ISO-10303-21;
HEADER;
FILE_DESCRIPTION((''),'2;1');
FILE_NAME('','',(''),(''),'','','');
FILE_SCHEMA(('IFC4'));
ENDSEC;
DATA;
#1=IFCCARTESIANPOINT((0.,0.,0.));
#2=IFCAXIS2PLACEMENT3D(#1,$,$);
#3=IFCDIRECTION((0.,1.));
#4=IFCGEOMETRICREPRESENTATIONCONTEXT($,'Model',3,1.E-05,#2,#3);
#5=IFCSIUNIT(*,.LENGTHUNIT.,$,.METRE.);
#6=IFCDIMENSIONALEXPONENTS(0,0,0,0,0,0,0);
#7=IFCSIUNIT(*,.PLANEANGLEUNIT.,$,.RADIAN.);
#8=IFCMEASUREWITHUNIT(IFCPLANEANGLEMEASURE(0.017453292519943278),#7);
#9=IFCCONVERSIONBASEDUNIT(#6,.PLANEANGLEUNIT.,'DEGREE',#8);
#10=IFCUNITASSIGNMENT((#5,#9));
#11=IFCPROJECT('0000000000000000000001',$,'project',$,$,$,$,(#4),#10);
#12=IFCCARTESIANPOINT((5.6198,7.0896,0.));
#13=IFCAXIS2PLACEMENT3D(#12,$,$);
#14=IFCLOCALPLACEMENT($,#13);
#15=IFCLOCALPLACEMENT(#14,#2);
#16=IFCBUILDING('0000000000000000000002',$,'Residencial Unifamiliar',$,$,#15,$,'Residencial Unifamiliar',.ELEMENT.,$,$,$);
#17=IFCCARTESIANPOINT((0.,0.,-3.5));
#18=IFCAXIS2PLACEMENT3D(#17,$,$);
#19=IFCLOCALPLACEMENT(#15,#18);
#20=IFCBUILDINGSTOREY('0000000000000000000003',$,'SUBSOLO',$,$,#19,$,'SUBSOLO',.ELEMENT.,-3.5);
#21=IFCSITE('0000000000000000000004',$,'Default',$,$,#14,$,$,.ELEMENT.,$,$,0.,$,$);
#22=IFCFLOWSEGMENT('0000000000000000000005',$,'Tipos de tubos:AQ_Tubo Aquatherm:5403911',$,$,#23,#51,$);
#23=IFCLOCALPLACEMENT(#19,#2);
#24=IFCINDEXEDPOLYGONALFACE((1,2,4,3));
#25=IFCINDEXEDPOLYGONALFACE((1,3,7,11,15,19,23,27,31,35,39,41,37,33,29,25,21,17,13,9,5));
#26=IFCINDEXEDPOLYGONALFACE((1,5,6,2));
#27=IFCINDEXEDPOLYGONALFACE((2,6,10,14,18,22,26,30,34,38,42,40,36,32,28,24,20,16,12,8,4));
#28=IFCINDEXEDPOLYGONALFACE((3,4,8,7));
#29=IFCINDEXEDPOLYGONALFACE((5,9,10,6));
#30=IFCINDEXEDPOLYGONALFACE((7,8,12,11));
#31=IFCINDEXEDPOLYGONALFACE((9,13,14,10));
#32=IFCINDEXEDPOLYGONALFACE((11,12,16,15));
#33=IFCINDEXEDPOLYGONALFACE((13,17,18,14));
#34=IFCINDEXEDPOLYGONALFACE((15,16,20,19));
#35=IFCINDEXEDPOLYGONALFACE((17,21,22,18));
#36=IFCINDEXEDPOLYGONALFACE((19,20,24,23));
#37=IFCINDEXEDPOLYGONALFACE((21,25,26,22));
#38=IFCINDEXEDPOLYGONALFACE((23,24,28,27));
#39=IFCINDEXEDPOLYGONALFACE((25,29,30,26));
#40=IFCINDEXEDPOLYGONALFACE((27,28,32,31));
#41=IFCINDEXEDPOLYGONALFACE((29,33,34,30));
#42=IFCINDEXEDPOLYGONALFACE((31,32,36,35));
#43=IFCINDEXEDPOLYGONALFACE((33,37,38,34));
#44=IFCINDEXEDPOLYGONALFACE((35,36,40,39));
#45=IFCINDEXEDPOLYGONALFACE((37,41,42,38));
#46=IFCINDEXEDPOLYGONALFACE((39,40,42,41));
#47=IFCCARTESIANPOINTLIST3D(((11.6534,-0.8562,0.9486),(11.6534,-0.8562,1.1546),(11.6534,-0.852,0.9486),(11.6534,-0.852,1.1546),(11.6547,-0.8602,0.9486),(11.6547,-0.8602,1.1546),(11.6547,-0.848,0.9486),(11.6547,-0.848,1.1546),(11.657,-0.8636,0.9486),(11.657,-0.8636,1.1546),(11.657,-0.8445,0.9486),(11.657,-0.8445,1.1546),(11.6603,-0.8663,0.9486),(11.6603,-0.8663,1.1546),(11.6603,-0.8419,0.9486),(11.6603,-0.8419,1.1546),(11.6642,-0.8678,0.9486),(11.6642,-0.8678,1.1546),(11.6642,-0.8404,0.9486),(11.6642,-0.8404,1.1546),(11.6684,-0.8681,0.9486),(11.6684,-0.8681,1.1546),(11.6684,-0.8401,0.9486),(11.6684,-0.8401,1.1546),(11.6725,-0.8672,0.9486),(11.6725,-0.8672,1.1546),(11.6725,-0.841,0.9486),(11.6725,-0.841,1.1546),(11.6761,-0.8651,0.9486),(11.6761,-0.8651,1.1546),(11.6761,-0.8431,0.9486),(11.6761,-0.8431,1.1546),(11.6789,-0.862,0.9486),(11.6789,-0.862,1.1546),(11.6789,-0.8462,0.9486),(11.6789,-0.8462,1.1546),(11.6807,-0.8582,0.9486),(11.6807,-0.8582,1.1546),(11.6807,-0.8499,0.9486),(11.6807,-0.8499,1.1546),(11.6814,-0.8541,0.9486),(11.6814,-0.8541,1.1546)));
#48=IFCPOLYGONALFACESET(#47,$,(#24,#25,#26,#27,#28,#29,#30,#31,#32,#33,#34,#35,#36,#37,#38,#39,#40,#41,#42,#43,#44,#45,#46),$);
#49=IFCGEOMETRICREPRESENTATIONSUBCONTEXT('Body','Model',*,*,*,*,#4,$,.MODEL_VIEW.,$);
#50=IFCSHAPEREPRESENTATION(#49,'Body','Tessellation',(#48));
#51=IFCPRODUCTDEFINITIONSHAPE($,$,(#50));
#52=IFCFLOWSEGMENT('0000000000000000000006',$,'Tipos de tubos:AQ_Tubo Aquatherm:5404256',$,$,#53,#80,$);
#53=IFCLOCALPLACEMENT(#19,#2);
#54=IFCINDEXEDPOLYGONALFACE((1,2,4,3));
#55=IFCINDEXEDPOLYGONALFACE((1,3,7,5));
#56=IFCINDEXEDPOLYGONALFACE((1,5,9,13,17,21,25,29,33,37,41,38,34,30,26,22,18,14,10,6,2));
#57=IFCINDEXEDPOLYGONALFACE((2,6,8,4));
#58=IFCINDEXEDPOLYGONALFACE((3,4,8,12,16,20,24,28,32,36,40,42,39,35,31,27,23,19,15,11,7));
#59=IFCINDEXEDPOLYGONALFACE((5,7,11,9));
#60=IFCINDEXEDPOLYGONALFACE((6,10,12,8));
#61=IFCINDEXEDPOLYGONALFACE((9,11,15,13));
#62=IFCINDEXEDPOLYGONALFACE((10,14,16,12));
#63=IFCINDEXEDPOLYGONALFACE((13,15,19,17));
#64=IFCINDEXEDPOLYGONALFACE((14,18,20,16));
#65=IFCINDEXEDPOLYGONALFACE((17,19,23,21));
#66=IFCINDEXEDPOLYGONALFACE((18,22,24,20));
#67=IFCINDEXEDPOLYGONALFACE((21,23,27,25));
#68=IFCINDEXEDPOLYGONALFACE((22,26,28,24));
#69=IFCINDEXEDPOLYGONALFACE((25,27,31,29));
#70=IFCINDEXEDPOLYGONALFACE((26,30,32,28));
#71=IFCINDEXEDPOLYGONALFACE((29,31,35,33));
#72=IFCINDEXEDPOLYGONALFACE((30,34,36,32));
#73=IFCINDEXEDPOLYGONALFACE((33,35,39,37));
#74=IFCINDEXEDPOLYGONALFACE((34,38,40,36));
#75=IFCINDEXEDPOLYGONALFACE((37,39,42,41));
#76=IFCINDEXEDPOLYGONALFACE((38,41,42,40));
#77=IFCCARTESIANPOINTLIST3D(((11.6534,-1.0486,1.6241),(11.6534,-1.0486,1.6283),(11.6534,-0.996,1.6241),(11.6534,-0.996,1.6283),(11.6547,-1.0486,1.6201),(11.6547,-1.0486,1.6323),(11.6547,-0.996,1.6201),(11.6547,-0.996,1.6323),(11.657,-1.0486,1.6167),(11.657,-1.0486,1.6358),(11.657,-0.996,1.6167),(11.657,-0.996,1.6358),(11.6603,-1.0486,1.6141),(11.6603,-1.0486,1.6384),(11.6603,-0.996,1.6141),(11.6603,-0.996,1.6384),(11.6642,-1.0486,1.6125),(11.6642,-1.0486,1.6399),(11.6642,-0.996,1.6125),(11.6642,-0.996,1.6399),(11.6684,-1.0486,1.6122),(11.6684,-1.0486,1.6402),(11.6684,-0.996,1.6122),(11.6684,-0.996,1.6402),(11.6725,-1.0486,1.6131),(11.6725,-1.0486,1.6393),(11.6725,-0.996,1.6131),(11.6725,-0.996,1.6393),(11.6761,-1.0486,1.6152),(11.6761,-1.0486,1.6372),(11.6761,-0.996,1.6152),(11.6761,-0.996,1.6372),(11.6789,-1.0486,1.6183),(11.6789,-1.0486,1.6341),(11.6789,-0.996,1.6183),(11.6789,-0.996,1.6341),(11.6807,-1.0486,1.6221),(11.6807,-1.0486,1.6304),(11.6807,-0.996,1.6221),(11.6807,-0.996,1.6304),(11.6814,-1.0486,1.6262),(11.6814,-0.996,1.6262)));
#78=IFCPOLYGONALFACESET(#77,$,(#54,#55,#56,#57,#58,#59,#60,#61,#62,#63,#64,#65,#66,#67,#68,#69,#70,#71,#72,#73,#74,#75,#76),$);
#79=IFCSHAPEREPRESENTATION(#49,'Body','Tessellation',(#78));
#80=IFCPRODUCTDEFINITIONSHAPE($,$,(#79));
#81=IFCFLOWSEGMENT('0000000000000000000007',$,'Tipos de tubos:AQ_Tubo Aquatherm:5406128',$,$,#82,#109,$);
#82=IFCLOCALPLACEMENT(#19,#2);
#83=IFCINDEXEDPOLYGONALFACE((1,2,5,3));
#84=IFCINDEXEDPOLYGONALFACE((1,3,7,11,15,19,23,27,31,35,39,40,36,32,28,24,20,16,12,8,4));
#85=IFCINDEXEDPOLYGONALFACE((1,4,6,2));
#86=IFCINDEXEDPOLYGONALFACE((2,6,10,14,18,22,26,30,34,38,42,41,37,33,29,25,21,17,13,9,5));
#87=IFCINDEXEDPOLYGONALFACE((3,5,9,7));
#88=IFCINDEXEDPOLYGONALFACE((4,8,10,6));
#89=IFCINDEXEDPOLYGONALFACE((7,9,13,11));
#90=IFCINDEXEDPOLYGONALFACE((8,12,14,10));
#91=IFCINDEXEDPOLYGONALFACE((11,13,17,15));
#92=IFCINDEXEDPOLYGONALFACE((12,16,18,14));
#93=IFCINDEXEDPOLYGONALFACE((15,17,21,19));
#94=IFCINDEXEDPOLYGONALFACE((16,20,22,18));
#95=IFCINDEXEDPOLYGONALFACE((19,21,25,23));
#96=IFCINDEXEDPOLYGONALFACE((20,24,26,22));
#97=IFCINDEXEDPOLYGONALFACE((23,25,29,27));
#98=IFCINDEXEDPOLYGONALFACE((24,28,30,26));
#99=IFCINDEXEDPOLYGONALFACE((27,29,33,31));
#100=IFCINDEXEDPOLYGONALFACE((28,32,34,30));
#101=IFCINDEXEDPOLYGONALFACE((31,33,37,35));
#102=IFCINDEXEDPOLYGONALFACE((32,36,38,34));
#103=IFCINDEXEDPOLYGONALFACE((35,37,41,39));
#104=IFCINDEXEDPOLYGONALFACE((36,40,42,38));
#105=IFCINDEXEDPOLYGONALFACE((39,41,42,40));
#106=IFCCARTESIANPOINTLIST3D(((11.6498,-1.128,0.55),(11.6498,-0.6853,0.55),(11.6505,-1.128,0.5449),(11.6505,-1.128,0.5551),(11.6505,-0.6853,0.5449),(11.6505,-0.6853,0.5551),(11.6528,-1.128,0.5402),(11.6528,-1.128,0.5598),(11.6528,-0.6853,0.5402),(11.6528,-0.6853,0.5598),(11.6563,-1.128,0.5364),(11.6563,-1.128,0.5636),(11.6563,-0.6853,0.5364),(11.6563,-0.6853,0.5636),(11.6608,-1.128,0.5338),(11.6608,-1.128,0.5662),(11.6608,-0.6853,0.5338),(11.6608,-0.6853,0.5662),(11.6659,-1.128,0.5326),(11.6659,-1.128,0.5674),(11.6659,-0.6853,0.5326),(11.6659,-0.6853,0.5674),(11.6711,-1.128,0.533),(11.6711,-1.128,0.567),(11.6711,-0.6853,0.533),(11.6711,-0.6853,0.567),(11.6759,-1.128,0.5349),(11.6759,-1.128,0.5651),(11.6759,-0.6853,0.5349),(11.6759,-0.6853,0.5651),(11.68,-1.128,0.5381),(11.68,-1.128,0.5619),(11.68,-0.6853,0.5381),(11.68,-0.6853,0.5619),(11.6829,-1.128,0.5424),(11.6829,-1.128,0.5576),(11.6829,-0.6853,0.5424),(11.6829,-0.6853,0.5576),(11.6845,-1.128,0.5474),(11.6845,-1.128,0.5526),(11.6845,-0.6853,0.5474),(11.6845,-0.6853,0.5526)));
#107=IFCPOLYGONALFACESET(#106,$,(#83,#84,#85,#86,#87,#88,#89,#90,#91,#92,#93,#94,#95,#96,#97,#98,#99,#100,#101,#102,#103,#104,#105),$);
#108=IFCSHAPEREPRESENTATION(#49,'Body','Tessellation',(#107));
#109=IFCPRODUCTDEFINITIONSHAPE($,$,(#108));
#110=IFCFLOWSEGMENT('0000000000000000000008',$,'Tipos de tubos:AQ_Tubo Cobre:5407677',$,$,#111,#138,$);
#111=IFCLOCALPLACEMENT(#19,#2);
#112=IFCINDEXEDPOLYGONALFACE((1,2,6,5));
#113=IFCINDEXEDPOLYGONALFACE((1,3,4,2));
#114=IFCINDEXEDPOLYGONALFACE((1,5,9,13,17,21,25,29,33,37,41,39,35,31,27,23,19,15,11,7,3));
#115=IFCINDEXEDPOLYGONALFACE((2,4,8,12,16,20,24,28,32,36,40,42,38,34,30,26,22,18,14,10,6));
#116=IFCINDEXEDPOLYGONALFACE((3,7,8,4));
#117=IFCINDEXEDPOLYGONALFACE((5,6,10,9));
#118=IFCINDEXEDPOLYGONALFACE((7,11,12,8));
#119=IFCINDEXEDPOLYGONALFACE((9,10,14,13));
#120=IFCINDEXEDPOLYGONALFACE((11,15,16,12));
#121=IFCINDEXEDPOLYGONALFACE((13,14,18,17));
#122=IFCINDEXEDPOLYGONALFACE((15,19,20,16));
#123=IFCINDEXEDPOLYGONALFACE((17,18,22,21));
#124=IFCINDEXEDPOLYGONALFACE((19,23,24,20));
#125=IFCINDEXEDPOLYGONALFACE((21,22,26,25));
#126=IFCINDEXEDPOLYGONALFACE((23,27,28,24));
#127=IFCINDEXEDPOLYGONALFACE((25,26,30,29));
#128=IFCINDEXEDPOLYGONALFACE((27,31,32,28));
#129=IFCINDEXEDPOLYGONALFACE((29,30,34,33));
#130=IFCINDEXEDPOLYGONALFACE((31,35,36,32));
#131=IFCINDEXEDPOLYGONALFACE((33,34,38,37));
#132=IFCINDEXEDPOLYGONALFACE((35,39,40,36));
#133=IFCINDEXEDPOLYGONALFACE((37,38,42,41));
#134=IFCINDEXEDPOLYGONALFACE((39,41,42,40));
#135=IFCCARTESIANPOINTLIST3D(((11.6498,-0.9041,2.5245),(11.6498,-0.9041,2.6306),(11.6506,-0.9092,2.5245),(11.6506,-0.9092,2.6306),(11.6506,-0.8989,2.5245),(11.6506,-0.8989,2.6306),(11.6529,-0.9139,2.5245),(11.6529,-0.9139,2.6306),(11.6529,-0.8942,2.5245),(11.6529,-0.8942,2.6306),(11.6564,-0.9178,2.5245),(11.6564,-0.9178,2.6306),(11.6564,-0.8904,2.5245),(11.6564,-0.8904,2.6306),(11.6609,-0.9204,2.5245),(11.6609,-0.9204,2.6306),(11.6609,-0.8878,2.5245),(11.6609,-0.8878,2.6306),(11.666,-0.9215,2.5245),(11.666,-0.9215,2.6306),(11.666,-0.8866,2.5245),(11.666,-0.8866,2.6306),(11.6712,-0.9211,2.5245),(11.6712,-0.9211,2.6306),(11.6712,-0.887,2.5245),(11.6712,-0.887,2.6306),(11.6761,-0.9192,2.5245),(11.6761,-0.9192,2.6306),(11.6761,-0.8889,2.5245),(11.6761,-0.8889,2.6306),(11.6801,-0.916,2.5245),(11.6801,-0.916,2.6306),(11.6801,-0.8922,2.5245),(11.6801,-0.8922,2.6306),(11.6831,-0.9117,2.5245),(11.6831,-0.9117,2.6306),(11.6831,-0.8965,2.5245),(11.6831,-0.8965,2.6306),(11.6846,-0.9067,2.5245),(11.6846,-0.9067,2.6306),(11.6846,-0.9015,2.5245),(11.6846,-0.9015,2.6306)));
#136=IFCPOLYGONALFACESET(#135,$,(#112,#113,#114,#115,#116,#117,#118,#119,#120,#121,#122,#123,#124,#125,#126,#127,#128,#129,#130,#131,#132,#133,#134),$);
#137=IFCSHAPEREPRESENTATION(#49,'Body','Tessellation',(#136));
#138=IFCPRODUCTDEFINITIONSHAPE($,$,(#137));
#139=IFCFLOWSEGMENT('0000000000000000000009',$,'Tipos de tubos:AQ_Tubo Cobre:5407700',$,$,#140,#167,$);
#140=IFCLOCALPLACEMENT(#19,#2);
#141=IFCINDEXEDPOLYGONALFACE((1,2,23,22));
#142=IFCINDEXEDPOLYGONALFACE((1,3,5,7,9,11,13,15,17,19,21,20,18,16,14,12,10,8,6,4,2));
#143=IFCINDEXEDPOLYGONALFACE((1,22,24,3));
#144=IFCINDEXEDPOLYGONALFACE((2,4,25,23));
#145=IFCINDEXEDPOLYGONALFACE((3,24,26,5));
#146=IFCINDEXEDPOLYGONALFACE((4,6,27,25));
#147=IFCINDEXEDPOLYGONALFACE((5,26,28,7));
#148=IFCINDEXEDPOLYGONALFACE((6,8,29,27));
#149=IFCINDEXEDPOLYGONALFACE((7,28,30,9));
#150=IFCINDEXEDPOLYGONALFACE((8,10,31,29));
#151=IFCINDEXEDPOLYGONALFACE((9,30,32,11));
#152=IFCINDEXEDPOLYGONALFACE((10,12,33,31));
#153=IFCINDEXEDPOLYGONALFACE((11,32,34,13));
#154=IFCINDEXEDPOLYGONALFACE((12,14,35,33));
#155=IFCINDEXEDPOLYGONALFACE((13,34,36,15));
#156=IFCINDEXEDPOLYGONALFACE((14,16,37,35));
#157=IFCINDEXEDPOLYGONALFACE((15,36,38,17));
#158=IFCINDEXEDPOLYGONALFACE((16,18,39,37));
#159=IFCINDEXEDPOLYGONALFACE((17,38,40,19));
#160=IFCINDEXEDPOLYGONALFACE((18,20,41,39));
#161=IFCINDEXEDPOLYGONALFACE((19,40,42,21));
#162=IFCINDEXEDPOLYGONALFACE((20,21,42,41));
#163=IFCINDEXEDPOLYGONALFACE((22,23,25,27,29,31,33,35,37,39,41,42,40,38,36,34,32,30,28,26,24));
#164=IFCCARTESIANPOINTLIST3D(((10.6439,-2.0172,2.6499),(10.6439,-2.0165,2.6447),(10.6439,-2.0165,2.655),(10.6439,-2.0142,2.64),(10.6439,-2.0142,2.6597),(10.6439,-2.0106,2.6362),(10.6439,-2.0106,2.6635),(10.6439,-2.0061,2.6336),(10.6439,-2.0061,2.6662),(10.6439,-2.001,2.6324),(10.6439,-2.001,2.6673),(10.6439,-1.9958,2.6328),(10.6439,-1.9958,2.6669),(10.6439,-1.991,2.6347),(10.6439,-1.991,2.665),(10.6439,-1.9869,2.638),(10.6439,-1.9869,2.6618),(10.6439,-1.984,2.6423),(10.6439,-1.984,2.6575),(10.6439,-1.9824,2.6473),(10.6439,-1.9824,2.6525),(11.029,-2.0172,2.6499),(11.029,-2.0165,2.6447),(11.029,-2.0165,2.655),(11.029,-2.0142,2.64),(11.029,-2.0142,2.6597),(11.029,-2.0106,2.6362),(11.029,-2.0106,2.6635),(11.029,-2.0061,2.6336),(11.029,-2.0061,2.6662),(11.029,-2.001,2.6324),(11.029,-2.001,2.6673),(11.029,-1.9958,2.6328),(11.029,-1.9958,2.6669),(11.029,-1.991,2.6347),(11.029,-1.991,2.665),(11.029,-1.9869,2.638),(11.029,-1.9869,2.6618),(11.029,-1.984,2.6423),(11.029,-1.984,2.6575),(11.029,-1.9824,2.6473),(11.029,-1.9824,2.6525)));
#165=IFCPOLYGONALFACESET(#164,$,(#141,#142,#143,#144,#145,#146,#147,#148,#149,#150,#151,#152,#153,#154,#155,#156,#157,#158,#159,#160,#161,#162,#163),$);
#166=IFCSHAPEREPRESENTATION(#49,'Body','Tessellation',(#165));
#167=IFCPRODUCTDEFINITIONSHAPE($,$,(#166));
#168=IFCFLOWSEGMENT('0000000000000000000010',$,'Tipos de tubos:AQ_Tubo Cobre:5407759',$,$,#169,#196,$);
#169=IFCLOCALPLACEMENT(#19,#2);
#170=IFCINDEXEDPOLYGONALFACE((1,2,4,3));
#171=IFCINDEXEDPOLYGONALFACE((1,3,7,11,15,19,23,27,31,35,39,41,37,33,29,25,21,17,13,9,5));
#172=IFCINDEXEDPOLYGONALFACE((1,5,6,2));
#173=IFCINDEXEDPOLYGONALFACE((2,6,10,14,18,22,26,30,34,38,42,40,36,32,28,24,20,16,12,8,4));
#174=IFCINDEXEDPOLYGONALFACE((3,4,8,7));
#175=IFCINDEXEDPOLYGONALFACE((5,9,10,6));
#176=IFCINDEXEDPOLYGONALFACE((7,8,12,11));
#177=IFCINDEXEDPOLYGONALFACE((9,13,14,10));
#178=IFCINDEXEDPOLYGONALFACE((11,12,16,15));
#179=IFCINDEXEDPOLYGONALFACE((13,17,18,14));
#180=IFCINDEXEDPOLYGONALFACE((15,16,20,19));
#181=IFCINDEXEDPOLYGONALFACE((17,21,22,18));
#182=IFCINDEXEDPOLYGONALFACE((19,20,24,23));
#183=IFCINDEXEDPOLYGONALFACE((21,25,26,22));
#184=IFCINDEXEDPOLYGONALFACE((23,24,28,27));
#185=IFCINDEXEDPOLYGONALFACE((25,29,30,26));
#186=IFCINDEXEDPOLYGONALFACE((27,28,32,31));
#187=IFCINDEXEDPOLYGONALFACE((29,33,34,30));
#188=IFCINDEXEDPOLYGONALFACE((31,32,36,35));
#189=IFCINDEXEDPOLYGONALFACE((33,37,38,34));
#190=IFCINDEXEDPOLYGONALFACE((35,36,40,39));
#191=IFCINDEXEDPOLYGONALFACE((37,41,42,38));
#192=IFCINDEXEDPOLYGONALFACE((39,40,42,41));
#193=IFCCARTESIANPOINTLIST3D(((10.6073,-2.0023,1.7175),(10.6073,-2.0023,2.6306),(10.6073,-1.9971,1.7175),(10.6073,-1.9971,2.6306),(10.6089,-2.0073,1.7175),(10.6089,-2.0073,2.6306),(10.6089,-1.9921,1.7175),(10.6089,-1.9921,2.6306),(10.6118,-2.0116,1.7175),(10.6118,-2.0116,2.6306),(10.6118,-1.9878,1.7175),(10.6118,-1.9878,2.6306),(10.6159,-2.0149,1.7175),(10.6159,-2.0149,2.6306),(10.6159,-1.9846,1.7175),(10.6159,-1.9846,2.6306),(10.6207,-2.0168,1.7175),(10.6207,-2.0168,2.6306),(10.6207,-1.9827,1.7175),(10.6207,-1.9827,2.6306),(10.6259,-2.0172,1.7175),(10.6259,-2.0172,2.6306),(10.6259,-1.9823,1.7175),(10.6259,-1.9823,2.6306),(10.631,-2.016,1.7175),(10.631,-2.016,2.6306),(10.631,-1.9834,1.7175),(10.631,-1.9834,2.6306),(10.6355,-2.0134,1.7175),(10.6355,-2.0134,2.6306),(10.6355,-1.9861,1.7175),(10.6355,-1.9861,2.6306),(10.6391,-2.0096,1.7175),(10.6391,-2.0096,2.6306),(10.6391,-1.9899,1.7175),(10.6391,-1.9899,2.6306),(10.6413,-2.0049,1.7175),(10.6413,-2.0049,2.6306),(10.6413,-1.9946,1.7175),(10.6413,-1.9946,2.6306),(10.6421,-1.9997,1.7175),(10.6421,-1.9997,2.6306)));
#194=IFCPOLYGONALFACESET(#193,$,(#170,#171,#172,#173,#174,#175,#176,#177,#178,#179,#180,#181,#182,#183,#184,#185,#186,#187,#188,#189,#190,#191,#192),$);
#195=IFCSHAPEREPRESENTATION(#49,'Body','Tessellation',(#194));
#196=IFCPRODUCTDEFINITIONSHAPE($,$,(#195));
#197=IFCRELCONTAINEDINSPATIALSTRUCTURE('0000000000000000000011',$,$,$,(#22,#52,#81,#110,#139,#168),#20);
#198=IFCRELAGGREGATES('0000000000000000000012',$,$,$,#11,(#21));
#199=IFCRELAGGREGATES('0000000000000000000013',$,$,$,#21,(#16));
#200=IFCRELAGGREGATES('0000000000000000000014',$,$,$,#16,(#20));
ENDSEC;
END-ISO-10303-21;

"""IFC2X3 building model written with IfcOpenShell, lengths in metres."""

from ifc_helpers import new_model, entity, si_unit, converted_unit, direction, frame, frame_2d, origin, origin_2d_with_axis, place, context, subcontext, project, spatial, circle, extrude, element, save


model = new_model("IFC2X3")

# Units and contexts
model_context = context("Model", 3, precision=1e-05, world=origin(), true_north=direction((0.0, 1.0)))
body_context = subcontext(model_context, "Body", "Model", "MODEL_VIEW")
ifc_project = project(units=[si_unit("LENGTHUNIT", "METRE"), converted_unit("PLANEANGLEUNIT", "DEGREE", entity("IfcPlaneAngleMeasure", 0.017453292519943278), si_unit("PLANEANGLEUNIT", "RADIAN"), dimensions=[0, 0, 0, 0, 0, 0, 0])], contexts=[model_context])

# Site, building, storey
site_placement = place(None, frame((5.6198, 7.0896, 0.0)))
site = spatial("IfcSite", under=ifc_project, at=site_placement, Name="Default", CompositionType="ELEMENT", RefElevation=0.0)
building_placement = place(site_placement, origin())
building = spatial("IfcBuilding", under=site, at=building_placement, Name="Residencial Unifamiliar", LongName="Residencial Unifamiliar", CompositionType="ELEMENT")
storey_placement = place(building_placement, frame((0.0, 0.0, -3.5)))
storey = spatial("IfcBuildingStorey", under=building, at=storey_placement, Name="SUBSOLO", LongName="SUBSOLO", CompositionType="ELEMENT", Elevation=-3.5)

# Flow segments
flow_segment_1_placement = place(storey_placement, origin())
element("IfcFlowSegment", 1, at=flow_segment_1_placement, inside=storey, Name="Tipos de tubos:AQ_Tubo Aquatherm:5403911", context=body_context, shape_type="SweptSolid", body=[
    extrude(circle(Radius=0.0141, at=origin_2d_with_axis()), frame((11.6673, -0.8541, 0.9486)), (0.0, 0.0, 1.0), 0.2061),
])
flow_segment_2_placement = place(storey_placement, origin())
element("IfcFlowSegment", 2, at=flow_segment_2_placement, inside=storey, Name="Tipos de tubos:AQ_Tubo Aquatherm:5404256", context=body_context, shape_type="SweptSolid", body=[
    extrude(circle(Radius=0.0141, at=origin_2d_with_axis()), frame((11.6673, -1.0486, 1.6262), z_axis=(0.0, 1.0, 0.0), x_axis=(1.0, 0.0, 0.0)), (0.0, 0.0, 1.0), 0.0526),
])
flow_segment_3_placement = place(storey_placement, origin())
element("IfcFlowSegment", 3, at=flow_segment_3_placement, inside=storey, Name="Tipos de tubos:AQ_Tubo Aquatherm:5406128", context=body_context, shape_type="SweptSolid", body=[
    extrude(circle(Radius=0.0175, at=frame_2d((0.0, 0.0), x_axis=(1.0, 0.0))), frame((11.6672, -1.128, 0.55), z_axis=(0.0, 1.0, 0.0), x_axis=(-1.0, 0.0, 0.0)), (0.0, 0.0, 1.0), 0.4428),
])
flow_segment_4_placement = place(storey_placement, origin())
element("IfcFlowSegment", 4, at=flow_segment_4_placement, inside=storey, Name="Tipos de tubos:AQ_Tubo Cobre:5407677", context=body_context, shape_type="SweptSolid", body=[
    extrude(circle(Radius=0.0175, at=frame_2d((0.0, 0.0), x_axis=(1.0, 0.0))), frame((11.6673, -0.9041, 2.5245), z_axis=(0.0, 0.0, 1.0), x_axis=(-1.0, 0.0, 0.0)), (0.0, 0.0, 1.0), 0.1061),
])
flow_segment_5_placement = place(storey_placement, origin())
element("IfcFlowSegment", 5, at=flow_segment_5_placement, inside=storey, Name="Tipos de tubos:AQ_Tubo Cobre:5407700", context=body_context, shape_type="SweptSolid", body=[
    extrude(circle(Radius=0.0175, at=origin_2d_with_axis()), frame((10.6439, -1.9997, 2.6499), z_axis=(1.0, 0.0, 0.0), x_axis=(0.0, -1.0, 0.0)), (0.0, 0.0, 1.0), 0.3851),
])
flow_segment_6_placement = place(storey_placement, origin())
element("IfcFlowSegment", 6, at=flow_segment_6_placement, inside=storey, Name="Tipos de tubos:AQ_Tubo Cobre:5407759", context=body_context, shape_type="SweptSolid", body=[
    extrude(circle(Radius=0.0175, at=frame_2d((0.0, 0.0), x_axis=(1.0, 0.0))), frame((10.6246, -1.9997, 1.7175)), (0.0, 0.0, 1.0), 0.9131),
])

save(model, "model.ifc")
